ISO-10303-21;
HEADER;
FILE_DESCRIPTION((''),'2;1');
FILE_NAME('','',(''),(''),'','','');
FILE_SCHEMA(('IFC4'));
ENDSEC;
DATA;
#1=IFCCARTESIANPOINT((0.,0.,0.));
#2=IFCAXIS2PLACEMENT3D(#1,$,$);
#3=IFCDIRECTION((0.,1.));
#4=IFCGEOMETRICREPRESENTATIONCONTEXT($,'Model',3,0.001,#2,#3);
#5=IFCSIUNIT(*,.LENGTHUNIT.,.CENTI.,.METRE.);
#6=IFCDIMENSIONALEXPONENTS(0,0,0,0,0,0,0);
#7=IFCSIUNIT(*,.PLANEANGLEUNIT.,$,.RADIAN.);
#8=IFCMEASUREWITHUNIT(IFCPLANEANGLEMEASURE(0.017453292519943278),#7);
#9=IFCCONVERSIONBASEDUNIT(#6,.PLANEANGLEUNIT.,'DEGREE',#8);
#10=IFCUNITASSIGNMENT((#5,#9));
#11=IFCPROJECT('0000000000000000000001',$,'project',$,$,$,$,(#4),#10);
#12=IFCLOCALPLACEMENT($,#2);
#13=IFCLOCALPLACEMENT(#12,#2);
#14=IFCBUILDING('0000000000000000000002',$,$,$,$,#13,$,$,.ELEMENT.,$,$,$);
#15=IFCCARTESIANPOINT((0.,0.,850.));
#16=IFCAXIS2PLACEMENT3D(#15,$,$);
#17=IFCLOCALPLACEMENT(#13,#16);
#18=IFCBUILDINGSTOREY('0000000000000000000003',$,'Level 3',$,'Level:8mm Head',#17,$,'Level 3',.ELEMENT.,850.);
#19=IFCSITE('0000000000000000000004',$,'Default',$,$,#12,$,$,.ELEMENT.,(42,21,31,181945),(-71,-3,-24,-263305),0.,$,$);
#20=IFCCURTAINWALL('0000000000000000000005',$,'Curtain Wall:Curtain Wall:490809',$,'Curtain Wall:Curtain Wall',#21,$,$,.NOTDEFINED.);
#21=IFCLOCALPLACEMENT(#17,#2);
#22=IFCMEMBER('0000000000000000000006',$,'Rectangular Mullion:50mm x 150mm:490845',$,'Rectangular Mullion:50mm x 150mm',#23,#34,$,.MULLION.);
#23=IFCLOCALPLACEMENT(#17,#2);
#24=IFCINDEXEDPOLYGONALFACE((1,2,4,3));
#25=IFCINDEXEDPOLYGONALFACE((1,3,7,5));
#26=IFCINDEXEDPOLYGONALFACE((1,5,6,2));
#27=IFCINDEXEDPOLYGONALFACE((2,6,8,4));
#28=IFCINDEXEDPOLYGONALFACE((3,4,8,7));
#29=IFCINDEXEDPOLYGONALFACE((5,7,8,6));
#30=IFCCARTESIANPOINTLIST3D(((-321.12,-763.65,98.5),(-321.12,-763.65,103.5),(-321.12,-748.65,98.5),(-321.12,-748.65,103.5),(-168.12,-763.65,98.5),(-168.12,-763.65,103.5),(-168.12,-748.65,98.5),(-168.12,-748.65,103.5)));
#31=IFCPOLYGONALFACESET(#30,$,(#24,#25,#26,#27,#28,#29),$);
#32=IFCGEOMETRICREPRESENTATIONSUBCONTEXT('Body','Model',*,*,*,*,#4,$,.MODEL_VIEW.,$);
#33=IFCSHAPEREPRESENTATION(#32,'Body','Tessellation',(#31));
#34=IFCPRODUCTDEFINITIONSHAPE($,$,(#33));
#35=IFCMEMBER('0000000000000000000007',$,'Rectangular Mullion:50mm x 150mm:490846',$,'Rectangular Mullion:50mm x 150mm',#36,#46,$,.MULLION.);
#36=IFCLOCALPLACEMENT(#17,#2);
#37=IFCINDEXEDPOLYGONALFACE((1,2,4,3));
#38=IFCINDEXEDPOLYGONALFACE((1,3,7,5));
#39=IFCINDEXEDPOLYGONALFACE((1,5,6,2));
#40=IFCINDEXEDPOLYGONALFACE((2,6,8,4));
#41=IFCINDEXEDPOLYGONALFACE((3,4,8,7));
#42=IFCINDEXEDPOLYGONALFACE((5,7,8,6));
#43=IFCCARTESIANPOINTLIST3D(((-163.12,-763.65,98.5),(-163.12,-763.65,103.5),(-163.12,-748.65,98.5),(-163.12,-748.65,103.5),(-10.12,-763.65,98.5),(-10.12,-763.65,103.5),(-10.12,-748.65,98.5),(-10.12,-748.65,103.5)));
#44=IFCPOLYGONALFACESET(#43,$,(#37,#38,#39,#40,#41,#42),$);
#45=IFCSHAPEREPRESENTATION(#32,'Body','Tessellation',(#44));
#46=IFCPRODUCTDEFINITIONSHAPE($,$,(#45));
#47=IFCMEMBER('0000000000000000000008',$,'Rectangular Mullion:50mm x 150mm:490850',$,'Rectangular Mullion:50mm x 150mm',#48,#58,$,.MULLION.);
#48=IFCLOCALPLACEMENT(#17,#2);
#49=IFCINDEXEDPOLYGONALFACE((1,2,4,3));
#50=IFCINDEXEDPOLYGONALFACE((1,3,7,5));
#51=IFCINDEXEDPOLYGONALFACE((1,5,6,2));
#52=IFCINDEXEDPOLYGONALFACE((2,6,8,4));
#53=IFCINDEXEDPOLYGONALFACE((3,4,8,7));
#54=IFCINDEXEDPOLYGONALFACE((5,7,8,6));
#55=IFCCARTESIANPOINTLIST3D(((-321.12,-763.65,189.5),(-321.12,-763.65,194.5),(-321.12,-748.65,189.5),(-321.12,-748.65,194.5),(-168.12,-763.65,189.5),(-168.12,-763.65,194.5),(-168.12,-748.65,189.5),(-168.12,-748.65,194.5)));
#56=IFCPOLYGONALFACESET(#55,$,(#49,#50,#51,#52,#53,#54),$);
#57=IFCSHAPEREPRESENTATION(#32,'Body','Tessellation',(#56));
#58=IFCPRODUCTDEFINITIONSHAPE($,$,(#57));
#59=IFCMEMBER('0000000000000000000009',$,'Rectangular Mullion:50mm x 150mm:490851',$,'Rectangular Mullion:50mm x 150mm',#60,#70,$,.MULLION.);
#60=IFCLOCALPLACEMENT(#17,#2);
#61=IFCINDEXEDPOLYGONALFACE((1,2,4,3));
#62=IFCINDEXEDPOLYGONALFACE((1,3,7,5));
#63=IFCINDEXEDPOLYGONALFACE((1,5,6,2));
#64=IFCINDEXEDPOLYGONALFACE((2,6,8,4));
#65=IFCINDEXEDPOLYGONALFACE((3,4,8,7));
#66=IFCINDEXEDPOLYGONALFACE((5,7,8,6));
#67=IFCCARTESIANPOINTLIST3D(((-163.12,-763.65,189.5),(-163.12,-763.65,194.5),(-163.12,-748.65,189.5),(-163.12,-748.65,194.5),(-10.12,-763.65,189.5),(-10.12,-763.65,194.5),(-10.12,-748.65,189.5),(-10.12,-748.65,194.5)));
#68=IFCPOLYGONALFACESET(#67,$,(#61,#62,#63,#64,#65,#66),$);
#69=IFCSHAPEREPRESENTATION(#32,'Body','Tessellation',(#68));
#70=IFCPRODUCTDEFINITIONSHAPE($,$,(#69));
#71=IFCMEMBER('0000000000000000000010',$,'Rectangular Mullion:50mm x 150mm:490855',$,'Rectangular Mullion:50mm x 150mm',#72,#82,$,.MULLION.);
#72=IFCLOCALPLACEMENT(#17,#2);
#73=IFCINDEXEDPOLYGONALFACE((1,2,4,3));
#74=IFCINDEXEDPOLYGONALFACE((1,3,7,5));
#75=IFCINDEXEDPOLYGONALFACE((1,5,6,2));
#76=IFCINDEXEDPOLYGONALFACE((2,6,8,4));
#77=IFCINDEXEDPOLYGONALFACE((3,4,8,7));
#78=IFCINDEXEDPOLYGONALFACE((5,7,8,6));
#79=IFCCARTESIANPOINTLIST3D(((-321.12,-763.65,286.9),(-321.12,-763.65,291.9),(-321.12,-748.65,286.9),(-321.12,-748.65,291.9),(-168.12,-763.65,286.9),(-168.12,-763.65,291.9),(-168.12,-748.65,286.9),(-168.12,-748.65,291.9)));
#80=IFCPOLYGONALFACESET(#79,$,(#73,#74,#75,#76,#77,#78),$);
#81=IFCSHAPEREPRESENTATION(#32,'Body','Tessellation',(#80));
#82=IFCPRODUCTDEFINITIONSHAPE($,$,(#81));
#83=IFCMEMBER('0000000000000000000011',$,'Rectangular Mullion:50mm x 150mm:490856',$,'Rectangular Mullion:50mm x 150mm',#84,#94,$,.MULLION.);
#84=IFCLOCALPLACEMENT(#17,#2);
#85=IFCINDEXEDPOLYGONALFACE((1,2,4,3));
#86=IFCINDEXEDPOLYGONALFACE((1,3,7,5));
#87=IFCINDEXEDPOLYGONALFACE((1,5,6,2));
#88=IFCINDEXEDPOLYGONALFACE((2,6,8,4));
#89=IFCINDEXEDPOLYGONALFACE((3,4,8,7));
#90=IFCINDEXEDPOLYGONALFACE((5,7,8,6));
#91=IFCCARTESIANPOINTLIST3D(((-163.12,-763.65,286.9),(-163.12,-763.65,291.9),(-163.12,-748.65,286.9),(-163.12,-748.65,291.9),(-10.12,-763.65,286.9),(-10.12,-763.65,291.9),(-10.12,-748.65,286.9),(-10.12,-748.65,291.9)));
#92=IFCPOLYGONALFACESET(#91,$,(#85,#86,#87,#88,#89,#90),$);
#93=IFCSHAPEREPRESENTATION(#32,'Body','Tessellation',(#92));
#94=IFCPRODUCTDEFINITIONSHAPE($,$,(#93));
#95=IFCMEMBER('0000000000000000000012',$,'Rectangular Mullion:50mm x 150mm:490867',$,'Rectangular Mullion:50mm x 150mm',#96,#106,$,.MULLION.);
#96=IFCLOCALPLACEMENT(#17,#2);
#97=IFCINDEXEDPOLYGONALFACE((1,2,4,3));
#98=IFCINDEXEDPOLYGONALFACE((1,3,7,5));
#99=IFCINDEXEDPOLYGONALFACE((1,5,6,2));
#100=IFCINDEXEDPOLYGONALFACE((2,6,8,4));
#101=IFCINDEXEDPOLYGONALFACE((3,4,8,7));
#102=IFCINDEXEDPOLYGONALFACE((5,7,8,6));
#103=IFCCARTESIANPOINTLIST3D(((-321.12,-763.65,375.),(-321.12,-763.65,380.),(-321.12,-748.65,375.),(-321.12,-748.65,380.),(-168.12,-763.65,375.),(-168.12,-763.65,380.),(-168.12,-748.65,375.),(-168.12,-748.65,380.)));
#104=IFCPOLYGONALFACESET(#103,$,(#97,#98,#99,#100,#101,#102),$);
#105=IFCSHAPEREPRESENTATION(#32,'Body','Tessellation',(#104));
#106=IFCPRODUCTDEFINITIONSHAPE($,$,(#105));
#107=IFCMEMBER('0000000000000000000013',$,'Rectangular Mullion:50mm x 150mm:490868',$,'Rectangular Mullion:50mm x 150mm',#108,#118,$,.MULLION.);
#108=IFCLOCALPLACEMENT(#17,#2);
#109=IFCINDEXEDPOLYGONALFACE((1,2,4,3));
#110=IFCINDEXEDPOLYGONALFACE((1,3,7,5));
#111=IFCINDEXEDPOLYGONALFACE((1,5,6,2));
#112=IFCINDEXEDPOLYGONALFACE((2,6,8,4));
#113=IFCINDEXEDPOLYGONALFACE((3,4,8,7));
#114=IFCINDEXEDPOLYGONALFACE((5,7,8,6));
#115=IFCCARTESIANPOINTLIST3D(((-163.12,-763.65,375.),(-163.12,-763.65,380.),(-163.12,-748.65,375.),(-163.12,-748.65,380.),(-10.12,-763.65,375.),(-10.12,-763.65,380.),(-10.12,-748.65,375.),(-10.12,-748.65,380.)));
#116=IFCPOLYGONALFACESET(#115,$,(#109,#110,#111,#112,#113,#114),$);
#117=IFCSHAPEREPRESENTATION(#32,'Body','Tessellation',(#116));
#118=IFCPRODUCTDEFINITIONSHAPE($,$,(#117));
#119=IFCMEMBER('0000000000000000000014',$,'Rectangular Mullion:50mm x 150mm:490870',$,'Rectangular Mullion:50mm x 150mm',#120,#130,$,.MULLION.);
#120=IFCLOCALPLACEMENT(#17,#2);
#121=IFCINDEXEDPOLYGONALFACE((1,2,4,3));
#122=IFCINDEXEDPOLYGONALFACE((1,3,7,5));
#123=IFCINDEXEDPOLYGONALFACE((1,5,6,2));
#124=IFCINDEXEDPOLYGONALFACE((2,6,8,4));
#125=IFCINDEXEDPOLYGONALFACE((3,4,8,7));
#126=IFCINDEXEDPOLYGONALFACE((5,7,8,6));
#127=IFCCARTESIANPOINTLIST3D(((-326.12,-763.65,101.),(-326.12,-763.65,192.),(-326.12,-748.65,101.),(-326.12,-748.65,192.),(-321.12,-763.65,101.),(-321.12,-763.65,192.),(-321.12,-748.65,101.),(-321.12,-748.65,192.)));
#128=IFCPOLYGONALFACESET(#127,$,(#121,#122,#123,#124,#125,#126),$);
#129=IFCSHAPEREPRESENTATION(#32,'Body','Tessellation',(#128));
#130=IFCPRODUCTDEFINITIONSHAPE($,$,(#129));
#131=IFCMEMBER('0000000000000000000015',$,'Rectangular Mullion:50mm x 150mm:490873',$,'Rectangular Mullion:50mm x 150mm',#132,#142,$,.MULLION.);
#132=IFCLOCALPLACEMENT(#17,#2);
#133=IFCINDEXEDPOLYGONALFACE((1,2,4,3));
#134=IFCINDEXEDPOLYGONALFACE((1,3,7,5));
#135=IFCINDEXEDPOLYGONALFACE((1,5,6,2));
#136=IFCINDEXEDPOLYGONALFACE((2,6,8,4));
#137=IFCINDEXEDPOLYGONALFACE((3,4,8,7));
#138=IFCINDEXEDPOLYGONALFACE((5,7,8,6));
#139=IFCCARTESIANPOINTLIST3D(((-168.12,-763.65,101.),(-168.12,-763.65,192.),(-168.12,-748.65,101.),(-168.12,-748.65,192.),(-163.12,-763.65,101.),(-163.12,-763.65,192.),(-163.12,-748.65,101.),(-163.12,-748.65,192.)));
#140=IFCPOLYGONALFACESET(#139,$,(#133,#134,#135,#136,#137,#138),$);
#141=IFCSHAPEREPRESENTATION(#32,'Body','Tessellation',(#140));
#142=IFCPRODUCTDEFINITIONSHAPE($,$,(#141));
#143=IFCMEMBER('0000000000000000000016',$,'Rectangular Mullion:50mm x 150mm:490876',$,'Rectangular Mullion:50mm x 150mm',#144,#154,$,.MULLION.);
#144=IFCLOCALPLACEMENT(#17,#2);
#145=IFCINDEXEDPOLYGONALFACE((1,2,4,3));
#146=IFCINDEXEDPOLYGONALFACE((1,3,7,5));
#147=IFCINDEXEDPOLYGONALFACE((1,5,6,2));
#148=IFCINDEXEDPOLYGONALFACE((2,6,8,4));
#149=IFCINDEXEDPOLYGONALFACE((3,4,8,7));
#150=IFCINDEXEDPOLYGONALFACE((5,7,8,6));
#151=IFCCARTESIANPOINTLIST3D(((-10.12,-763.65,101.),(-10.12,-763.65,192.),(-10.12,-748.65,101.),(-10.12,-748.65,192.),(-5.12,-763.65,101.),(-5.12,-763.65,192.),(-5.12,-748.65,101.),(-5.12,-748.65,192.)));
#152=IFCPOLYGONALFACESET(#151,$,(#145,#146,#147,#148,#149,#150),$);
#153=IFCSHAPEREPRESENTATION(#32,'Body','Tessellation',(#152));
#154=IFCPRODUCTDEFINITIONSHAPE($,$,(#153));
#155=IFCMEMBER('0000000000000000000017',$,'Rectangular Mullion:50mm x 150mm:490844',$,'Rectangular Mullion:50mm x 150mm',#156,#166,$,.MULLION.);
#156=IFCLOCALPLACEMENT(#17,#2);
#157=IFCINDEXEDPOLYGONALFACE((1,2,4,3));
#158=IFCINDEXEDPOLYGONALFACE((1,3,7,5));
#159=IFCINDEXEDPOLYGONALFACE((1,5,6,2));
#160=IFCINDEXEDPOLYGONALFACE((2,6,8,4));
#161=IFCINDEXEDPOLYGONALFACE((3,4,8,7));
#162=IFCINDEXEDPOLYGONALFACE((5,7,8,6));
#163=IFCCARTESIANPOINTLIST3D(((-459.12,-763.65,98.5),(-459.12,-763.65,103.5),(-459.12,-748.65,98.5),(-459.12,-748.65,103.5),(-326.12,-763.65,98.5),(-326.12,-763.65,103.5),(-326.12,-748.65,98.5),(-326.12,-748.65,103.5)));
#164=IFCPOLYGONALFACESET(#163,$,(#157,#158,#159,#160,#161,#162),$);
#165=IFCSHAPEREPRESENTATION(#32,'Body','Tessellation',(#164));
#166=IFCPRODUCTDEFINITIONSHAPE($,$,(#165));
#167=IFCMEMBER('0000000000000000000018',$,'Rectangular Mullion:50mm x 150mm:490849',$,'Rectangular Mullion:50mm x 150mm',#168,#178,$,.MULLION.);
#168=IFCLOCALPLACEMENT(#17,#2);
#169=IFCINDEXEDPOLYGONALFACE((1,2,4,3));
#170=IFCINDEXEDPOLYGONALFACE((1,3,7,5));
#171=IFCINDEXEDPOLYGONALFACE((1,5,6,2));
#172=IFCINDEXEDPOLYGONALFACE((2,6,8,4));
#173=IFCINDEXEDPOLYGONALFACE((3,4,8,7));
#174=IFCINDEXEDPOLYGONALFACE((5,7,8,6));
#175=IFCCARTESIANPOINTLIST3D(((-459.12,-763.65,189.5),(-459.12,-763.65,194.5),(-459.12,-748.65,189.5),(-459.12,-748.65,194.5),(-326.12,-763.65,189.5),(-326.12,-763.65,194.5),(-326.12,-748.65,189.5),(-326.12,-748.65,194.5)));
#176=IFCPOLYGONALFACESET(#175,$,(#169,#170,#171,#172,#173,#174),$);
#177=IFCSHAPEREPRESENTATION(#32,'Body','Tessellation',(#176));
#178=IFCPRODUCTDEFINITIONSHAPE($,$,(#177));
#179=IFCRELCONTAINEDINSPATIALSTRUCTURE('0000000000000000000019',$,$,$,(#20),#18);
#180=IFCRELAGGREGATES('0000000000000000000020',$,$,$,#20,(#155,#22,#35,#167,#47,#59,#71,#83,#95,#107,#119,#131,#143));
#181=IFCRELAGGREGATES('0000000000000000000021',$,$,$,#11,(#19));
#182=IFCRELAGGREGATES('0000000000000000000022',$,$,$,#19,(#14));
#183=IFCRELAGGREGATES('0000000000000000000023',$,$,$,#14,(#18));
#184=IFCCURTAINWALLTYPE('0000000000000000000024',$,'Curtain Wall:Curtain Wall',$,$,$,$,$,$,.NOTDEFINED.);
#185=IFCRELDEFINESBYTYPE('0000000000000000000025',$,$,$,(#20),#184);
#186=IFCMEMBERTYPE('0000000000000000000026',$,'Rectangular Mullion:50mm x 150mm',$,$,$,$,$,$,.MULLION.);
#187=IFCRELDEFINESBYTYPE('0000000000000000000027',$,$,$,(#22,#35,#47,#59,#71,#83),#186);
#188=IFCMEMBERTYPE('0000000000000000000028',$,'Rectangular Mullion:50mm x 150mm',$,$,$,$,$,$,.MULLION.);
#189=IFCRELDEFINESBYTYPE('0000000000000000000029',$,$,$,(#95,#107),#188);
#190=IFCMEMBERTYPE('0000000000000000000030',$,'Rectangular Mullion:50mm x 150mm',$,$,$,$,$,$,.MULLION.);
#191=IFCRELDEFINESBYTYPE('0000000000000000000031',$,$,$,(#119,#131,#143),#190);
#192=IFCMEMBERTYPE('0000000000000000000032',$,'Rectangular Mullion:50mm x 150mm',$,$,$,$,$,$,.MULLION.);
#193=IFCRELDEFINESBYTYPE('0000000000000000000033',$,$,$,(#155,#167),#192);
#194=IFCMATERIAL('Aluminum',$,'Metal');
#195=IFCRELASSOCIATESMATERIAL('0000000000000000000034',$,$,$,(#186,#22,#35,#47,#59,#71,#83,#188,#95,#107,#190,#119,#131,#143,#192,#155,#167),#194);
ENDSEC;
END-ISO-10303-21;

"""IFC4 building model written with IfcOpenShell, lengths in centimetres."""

from ifc_helpers import new_model, entity, si_unit, converted_unit, direction, frame, origin, place, context, subcontext, project, spatial, indexed_curve, outline, extrude, source, transform, mapped, material, type_object, type_shapes, element, aggregate, save


model = new_model("IFC4")

# Units and contexts
model_context = context("Model", 3, precision=0.001, world=origin(), true_north=direction((0.0, 1.0)))
body_context = subcontext(model_context, "Body", "Model", "MODEL_VIEW")
ifc_project = project(units=[si_unit("LENGTHUNIT", "METRE", prefix="CENTI"), converted_unit("PLANEANGLEUNIT", "DEGREE", entity("IfcPlaneAngleMeasure", 0.017453292519943278), si_unit("PLANEANGLEUNIT", "RADIAN"), dimensions=[0, 0, 0, 0, 0, 0, 0])], contexts=[model_context])

# Site, building, storey
site_placement = place(None, origin())
site = spatial("IfcSite", under=ifc_project, at=site_placement, Name="Default", CompositionType="ELEMENT", RefLatitude=(42, 21, 31, 181945), RefLongitude=(-71, -3, -24, -263305), RefElevation=0.0)
building_placement = place(site_placement, origin())
building = spatial("IfcBuilding", under=site, at=building_placement, CompositionType="ELEMENT")
storey_placement = place(building_placement, frame((0.0, 0.0, 850.0)))
storey = spatial("IfcBuildingStorey", under=building, at=storey_placement, Name="Level 3", ObjectType="Level:8mm Head", LongName="Level 3", CompositionType="ELEMENT", Elevation=850.0)

# Curtain wall, members
curtain_wall_type = type_object("IfcCurtainWallType", Name="Curtain Wall:Curtain Wall", PredefinedType="NOTDEFINED")
curtain_wall_placement = place(storey_placement, frame((0.0, 0.0, -850.0)))
curtain_wall = element("IfcCurtainWall", 1, at=curtain_wall_placement, inside=storey, type_object=curtain_wall_type, Name="Curtain Wall:Curtain Wall:490809", ObjectType="Curtain Wall:Curtain Wall", PredefinedType="NOTDEFINED")
ifc_material_1 = material(Name="Aluminum", Category="Metal")
member_type_1 = type_object("IfcMemberType", Name="Rectangular Mullion:50mm x 150mm", PredefinedType="MULLION", material=ifc_material_1)
shared_shape_1 = source(origin(), body_context, "Body", "SweptSolid", [
    extrude(outline(indexed_curve([(-2.5, -7.5), (2.5, -7.5), (2.5, 7.5), (-2.5, 7.5), (-2.5, -7.5)], self_intersect=False)), frame((0.0, 0.0, -153.0), z_axis=(0.0, 0.0, 1.0), x_axis=(-1.0, 0.0, 0.0)), (0.0, 0.0, 1.0), 153.0),
])
type_shapes(member_type_1, [shared_shape_1])
member_1_placement = place(curtain_wall_placement, frame((-168.12, -756.15, 951.0), z_axis=(1.0, 0.0, 0.0), x_axis=(0.0, 0.0, 1.0)))
member_1 = element("IfcMember", 2, at=member_1_placement, type_object=member_type_1, material=ifc_material_1, Name="Rectangular Mullion:50mm x 150mm:490845", ObjectType="Rectangular Mullion:50mm x 150mm", PredefinedType="MULLION", context=body_context, shape_type="MappedRepresentation", body=[
    mapped(shared_shape_1, transform((0.0, 0.0, 0.0), scale=1.0)),
])
member_2_placement = place(curtain_wall_placement, frame((-10.12, -756.15, 951.0), z_axis=(1.0, 0.0, 0.0), x_axis=(0.0, 0.0, 1.0)))
member_2 = element("IfcMember", 3, at=member_2_placement, type_object=member_type_1, material=ifc_material_1, Name="Rectangular Mullion:50mm x 150mm:490846", ObjectType="Rectangular Mullion:50mm x 150mm", PredefinedType="MULLION", context=body_context, shape_type="MappedRepresentation", body=[
    mapped(shared_shape_1, transform((0.0, 0.0, 0.0), scale=1.0)),
])
member_3_placement = place(curtain_wall_placement, frame((-168.12, -756.15, 1042.0), z_axis=(1.0, 0.0, 0.0), x_axis=(0.0, 0.0, 1.0)))
member_3 = element("IfcMember", 4, at=member_3_placement, type_object=member_type_1, material=ifc_material_1, Name="Rectangular Mullion:50mm x 150mm:490850", ObjectType="Rectangular Mullion:50mm x 150mm", PredefinedType="MULLION", context=body_context, shape_type="MappedRepresentation", body=[
    mapped(shared_shape_1, transform((0.0, 0.0, 0.0), scale=1.0)),
])
member_4_placement = place(curtain_wall_placement, frame((-10.12, -756.15, 1042.0), z_axis=(1.0, 0.0, 0.0), x_axis=(0.0, 0.0, 1.0)))
member_4 = element("IfcMember", 5, at=member_4_placement, type_object=member_type_1, material=ifc_material_1, Name="Rectangular Mullion:50mm x 150mm:490851", ObjectType="Rectangular Mullion:50mm x 150mm", PredefinedType="MULLION", context=body_context, shape_type="MappedRepresentation", body=[
    mapped(shared_shape_1, transform((0.0, 0.0, 0.0), scale=1.0)),
])
member_5_placement = place(curtain_wall_placement, frame((-168.12, -756.15, 1139.4), z_axis=(1.0, 0.0, 0.0), x_axis=(0.0, 0.0, 1.0)))
member_5 = element("IfcMember", 6, at=member_5_placement, type_object=member_type_1, material=ifc_material_1, Name="Rectangular Mullion:50mm x 150mm:490855", ObjectType="Rectangular Mullion:50mm x 150mm", PredefinedType="MULLION", context=body_context, shape_type="MappedRepresentation", body=[
    mapped(shared_shape_1, transform((0.0, 0.0, 0.0), scale=1.0)),
])
member_6_placement = place(curtain_wall_placement, frame((-10.12, -756.15, 1139.4), z_axis=(1.0, 0.0, 0.0), x_axis=(0.0, 0.0, 1.0)))
member_6 = element("IfcMember", 7, at=member_6_placement, type_object=member_type_1, material=ifc_material_1, Name="Rectangular Mullion:50mm x 150mm:490856", ObjectType="Rectangular Mullion:50mm x 150mm", PredefinedType="MULLION", context=body_context, shape_type="MappedRepresentation", body=[
    mapped(shared_shape_1, transform((0.0, 0.0, 0.0), scale=1.0)),
])
member_type_2 = type_object("IfcMemberType", Name="Rectangular Mullion:50mm x 150mm", PredefinedType="MULLION", material=ifc_material_1)
shared_shape_2 = source(origin(), body_context, "Body", "SweptSolid", [
    extrude(outline(indexed_curve([(-2.5, -7.5), (2.5, -7.5), (2.5, 7.5), (-2.5, 7.5), (-2.5, -7.5)], self_intersect=False)), frame((-2.5, 0.0, -153.0), z_axis=(0.0, 0.0, 1.0), x_axis=(-1.0, 0.0, 0.0)), (0.0, 0.0, 1.0), 153.0),
])
type_shapes(member_type_2, [shared_shape_2])
member_7_placement = place(curtain_wall_placement, frame((-168.12, -756.15, 1230.0), z_axis=(1.0, 0.0, 0.0), x_axis=(0.0, 0.0, 1.0)))
member_7 = element("IfcMember", 8, at=member_7_placement, type_object=member_type_2, material=ifc_material_1, Name="Rectangular Mullion:50mm x 150mm:490867", ObjectType="Rectangular Mullion:50mm x 150mm", PredefinedType="MULLION", context=body_context, shape_type="MappedRepresentation", body=[
    mapped(shared_shape_2, transform((0.0, 0.0, 0.0), scale=1.0)),
])
member_8_placement = place(curtain_wall_placement, frame((-10.12, -756.15, 1230.0), z_axis=(1.0, 0.0, 0.0), x_axis=(0.0, 0.0, 1.0)))
member_8 = element("IfcMember", 9, at=member_8_placement, type_object=member_type_2, material=ifc_material_1, Name="Rectangular Mullion:50mm x 150mm:490868", ObjectType="Rectangular Mullion:50mm x 150mm", PredefinedType="MULLION", context=body_context, shape_type="MappedRepresentation", body=[
    mapped(shared_shape_2, transform((0.0, 0.0, 0.0), scale=1.0)),
])
member_type_3 = type_object("IfcMemberType", Name="Rectangular Mullion:50mm x 150mm", PredefinedType="MULLION", material=ifc_material_1)
shared_shape_3 = source(origin(), body_context, "Body", "SweptSolid", [
    extrude(outline(indexed_curve([(-2.5, -7.5), (2.5, -7.5), (2.5, 7.5), (-2.5, 7.5), (-2.5, -7.5)], self_intersect=False)), frame((0.0, 0.0, -91.0), z_axis=(0.0, 0.0, 1.0), x_axis=(-1.0, 0.0, 0.0)), (0.0, 0.0, 1.0), 91.0),
])
type_shapes(member_type_3, [shared_shape_3])
member_9_placement = place(curtain_wall_placement, frame((-323.62, -756.15, 951.0), z_axis=(0.0, 0.0, -1.0), x_axis=(1.0, 0.0, 0.0)))
member_9 = element("IfcMember", 10, at=member_9_placement, type_object=member_type_3, material=ifc_material_1, Name="Rectangular Mullion:50mm x 150mm:490870", ObjectType="Rectangular Mullion:50mm x 150mm", PredefinedType="MULLION", context=body_context, shape_type="MappedRepresentation", body=[
    mapped(shared_shape_3, transform((0.0, 0.0, 0.0), scale=1.0)),
])
member_10_placement = place(curtain_wall_placement, frame((-165.62, -756.15, 951.0), z_axis=(0.0, 0.0, -1.0), x_axis=(1.0, 0.0, 0.0)))
member_10 = element("IfcMember", 11, at=member_10_placement, type_object=member_type_3, material=ifc_material_1, Name="Rectangular Mullion:50mm x 150mm:490873", ObjectType="Rectangular Mullion:50mm x 150mm", PredefinedType="MULLION", context=body_context, shape_type="MappedRepresentation", body=[
    mapped(shared_shape_3, transform((0.0, 0.0, 0.0), scale=1.0)),
])
member_11_placement = place(curtain_wall_placement, frame((-7.62, -756.15, 951.0), z_axis=(0.0, 0.0, -1.0), x_axis=(1.0, 0.0, 0.0)))
member_11 = element("IfcMember", 12, at=member_11_placement, type_object=member_type_3, material=ifc_material_1, Name="Rectangular Mullion:50mm x 150mm:490876", ObjectType="Rectangular Mullion:50mm x 150mm", PredefinedType="MULLION", context=body_context, shape_type="MappedRepresentation", body=[
    mapped(shared_shape_3, transform((0.0, 0.0, 0.0), scale=1.0)),
])
member_type_4 = type_object("IfcMemberType", Name="Rectangular Mullion:50mm x 150mm", PredefinedType="MULLION", material=ifc_material_1)
shared_shape_4 = source(origin(), body_context, "Body", "SweptSolid", [
    extrude(outline(indexed_curve([(-2.5, -7.5), (2.5, -7.5), (2.5, 7.5), (-2.5, 7.5), (-2.5, -7.5)], self_intersect=False)), frame((0.0, 0.0, -133.0), z_axis=(0.0, 0.0, 1.0), x_axis=(-1.0, 0.0, 0.0)), (0.0, 0.0, 1.0), 133.0),
])
type_shapes(member_type_4, [shared_shape_4])
member_12_placement = place(curtain_wall_placement, frame((-326.12, -756.15, 951.0), z_axis=(1.0, 0.0, 0.0), x_axis=(0.0, 0.0, 1.0)))
member_12 = element("IfcMember", 13, at=member_12_placement, type_object=member_type_4, material=ifc_material_1, Name="Rectangular Mullion:50mm x 150mm:490844", ObjectType="Rectangular Mullion:50mm x 150mm", PredefinedType="MULLION", context=body_context, shape_type="MappedRepresentation", body=[
    mapped(shared_shape_4, transform((0.0, 0.0, 0.0), scale=1.0)),
])
member_13_placement = place(curtain_wall_placement, frame((-326.12, -756.15, 1042.0), z_axis=(1.0, 0.0, 0.0), x_axis=(0.0, 0.0, 1.0)))
member_13 = element("IfcMember", 14, at=member_13_placement, type_object=member_type_4, material=ifc_material_1, Name="Rectangular Mullion:50mm x 150mm:490849", ObjectType="Rectangular Mullion:50mm x 150mm", PredefinedType="MULLION", context=body_context, shape_type="MappedRepresentation", body=[
    mapped(shared_shape_4, transform((0.0, 0.0, 0.0), scale=1.0)),
])
aggregate(curtain_wall, [member_12, member_1, member_2, member_13, member_3, member_4, member_5, member_6, member_7, member_8, member_9, member_10, member_11])

save(model, "model.ifc")
